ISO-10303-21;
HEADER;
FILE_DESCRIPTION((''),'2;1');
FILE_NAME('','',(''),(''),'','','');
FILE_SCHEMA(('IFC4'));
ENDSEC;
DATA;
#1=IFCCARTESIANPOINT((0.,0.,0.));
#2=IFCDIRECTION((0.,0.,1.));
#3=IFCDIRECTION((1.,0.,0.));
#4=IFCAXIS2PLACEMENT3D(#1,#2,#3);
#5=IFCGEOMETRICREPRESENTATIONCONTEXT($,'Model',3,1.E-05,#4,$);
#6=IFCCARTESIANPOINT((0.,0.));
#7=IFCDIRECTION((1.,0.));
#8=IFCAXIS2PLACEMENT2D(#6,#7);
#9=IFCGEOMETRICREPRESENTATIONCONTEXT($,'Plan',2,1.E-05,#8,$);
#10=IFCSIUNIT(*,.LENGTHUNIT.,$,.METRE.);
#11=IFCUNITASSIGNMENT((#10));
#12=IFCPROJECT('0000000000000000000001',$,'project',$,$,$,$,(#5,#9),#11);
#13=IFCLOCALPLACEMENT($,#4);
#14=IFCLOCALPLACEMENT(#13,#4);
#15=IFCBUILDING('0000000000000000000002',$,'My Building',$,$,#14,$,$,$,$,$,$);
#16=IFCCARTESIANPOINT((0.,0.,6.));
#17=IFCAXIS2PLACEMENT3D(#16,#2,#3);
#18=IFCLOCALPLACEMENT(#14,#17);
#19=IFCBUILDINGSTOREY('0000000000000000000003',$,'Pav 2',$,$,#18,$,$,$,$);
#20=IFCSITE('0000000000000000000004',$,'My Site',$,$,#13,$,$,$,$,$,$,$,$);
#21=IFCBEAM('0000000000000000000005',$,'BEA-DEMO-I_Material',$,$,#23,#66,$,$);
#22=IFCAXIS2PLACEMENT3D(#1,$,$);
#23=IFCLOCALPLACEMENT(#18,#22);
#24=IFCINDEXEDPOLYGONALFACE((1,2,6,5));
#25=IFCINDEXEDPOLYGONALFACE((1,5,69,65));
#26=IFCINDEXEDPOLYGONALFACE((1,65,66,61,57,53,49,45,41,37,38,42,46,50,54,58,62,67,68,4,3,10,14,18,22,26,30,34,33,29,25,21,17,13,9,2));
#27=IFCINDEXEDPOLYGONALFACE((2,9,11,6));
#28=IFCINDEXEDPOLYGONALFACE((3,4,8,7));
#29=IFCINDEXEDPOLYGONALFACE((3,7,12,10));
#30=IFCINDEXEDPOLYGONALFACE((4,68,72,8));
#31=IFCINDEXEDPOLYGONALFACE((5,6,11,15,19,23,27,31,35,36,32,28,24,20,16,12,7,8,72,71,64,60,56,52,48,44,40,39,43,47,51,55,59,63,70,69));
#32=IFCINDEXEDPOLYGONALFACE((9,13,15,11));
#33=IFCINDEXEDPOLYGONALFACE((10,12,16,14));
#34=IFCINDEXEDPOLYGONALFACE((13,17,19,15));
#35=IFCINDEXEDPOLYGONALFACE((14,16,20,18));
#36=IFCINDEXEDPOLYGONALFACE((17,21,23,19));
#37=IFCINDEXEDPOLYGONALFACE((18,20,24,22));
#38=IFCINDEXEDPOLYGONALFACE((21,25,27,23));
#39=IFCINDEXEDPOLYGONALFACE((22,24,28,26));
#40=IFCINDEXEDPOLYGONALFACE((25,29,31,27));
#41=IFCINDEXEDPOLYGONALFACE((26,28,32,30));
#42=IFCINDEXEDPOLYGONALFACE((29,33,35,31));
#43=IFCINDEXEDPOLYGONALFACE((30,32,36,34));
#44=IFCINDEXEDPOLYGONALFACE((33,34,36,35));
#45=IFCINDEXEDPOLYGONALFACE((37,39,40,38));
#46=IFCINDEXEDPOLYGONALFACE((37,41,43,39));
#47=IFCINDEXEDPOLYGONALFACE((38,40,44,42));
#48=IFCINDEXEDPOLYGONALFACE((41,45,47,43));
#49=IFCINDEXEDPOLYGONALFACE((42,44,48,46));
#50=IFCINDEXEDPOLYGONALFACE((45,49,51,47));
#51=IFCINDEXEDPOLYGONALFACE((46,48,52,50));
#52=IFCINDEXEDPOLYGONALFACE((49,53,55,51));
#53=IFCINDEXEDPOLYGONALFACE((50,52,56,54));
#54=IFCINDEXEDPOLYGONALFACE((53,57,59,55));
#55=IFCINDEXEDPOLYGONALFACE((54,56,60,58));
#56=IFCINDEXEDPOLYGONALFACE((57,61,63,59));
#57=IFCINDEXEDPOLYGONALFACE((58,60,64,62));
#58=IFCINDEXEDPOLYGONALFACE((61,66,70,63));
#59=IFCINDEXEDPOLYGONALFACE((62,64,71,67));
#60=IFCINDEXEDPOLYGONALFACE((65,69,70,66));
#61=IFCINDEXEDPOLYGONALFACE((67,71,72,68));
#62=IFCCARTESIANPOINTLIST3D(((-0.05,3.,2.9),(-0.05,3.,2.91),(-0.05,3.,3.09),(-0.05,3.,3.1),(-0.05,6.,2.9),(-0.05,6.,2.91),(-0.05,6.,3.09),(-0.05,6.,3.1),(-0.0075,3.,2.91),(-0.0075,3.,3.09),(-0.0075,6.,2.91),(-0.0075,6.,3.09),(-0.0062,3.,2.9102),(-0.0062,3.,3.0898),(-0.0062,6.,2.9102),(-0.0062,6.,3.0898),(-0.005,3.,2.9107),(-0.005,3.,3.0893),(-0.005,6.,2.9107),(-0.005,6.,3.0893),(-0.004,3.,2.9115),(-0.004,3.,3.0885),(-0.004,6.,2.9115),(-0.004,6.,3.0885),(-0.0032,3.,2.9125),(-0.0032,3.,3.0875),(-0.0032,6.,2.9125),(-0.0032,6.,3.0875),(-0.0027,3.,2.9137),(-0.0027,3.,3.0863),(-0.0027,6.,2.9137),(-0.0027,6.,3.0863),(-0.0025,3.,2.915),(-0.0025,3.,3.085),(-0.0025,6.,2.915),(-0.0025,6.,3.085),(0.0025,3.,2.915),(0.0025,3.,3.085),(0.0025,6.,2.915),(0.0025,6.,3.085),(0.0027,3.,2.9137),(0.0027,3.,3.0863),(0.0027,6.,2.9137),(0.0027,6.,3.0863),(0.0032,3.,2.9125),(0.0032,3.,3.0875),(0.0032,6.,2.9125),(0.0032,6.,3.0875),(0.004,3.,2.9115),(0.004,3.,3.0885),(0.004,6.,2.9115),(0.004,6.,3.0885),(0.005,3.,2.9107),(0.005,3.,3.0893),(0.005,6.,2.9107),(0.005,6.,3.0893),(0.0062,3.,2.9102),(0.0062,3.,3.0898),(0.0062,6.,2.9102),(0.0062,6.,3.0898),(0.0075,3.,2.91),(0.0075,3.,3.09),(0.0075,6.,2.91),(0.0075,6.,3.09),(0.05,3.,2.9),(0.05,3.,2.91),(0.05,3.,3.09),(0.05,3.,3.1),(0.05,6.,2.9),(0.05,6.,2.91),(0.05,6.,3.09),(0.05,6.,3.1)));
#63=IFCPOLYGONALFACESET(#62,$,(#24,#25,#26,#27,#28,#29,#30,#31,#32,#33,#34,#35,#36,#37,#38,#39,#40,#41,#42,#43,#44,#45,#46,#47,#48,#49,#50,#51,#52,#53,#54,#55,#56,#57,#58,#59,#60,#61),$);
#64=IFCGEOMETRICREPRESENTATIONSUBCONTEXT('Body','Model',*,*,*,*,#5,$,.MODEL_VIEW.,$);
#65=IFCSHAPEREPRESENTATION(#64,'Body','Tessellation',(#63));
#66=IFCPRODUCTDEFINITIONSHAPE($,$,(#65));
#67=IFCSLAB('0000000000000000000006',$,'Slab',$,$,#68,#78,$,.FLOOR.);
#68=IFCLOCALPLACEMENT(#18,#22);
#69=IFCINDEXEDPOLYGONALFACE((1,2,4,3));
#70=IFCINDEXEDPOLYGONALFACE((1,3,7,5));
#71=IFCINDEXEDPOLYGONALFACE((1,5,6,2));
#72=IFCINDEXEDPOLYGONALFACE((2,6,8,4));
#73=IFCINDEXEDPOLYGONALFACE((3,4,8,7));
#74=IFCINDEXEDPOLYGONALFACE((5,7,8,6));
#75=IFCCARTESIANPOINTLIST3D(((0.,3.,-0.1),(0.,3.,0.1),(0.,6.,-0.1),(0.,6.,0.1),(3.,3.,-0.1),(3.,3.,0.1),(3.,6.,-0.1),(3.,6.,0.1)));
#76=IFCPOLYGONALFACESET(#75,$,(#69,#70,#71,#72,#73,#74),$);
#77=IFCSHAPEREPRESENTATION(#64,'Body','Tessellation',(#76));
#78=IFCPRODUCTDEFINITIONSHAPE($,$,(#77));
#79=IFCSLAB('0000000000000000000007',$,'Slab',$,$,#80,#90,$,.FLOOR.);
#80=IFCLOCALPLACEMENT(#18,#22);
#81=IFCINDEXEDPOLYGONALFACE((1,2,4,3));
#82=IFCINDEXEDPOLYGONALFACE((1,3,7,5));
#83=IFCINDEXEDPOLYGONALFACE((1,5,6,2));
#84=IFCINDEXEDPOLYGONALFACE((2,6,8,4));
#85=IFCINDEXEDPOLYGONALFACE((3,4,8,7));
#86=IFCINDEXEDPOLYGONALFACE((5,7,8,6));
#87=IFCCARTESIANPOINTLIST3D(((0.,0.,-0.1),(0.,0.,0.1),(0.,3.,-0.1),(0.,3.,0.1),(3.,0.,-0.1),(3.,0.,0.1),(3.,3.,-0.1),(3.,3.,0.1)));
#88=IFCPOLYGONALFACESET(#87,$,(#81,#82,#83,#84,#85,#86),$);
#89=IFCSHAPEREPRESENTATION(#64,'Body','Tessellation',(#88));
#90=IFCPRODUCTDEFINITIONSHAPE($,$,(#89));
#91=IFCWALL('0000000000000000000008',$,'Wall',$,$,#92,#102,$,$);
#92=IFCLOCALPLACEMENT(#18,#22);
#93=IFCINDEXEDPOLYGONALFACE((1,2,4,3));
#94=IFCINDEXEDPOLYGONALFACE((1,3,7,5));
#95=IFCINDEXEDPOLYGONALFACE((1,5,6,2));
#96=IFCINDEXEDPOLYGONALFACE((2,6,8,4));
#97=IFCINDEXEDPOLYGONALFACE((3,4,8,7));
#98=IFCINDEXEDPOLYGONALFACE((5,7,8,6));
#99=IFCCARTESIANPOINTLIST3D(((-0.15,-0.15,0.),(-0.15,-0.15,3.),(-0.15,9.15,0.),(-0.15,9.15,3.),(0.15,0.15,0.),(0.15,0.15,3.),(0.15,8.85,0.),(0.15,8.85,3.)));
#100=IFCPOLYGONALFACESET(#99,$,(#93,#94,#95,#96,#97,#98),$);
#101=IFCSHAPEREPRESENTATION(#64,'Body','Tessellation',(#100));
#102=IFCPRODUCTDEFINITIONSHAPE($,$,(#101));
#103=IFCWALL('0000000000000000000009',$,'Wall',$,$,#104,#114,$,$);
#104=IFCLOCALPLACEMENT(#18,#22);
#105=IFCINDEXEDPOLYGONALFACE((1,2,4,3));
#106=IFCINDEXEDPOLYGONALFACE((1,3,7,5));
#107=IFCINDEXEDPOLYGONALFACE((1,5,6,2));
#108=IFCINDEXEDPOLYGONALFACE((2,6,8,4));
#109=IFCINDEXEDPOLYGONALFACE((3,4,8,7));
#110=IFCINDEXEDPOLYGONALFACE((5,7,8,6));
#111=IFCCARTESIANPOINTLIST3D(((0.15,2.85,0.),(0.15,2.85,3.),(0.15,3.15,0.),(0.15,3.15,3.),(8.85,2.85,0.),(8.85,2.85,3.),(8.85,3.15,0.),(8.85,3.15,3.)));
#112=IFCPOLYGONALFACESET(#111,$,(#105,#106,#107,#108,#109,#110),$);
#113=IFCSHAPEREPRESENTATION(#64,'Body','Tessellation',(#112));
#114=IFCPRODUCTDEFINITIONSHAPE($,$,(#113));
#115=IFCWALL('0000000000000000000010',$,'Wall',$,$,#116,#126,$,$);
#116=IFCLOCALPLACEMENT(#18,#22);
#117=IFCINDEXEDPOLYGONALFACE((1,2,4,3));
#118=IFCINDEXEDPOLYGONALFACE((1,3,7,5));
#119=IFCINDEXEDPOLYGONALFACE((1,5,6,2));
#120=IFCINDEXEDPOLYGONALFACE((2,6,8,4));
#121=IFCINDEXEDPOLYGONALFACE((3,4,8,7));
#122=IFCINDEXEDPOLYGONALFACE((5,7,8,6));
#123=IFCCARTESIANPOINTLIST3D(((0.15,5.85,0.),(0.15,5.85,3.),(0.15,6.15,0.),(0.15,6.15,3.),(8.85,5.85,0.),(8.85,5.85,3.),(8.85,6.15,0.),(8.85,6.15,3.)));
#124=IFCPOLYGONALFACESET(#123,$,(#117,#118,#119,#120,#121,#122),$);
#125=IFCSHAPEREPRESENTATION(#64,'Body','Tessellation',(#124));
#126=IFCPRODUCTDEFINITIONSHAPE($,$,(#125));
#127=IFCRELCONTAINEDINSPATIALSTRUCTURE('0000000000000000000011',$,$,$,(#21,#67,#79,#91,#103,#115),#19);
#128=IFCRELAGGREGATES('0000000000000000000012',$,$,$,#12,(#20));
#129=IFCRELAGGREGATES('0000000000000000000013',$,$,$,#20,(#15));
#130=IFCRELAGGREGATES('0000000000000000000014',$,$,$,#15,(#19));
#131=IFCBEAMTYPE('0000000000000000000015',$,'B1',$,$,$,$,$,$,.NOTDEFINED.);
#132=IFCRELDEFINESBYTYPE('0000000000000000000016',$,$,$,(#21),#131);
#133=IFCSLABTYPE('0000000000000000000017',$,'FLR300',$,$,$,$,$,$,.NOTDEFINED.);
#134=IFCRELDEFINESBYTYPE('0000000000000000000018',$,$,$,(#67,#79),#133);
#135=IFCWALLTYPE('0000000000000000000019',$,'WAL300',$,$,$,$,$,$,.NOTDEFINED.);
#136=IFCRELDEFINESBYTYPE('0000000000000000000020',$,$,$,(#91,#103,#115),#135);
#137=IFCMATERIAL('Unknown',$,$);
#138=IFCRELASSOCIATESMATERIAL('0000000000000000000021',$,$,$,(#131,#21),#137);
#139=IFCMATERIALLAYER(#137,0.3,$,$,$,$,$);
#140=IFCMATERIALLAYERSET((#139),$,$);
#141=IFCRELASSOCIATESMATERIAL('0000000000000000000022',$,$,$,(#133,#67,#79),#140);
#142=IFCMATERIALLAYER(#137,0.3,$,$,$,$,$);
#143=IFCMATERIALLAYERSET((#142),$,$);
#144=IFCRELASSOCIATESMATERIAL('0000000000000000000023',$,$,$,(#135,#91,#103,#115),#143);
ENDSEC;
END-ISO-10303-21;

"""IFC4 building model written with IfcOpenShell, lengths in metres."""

from ifc_helpers import new_model, si_unit, frame, origin, origin_with_axes, origin_2d_with_axis, place, context, subcontext, project, spatial, polyline, line, indexed_curve, i_section, outline, extrude, material, layer, layer_set, layer_usage, material_profile, profile_set, profile_usage, type_object, element, save


model = new_model("IFC4")

# Units and contexts
model_context = context("Model", 3, precision=1e-05, world=origin_with_axes())
plan_context = context("Plan", 2, precision=1e-05, world=origin_2d_with_axis())
body_context = subcontext(model_context, "Body", "Model", "MODEL_VIEW")
ifc_project = project(units=[si_unit("LENGTHUNIT", "METRE")], contexts=[model_context, plan_context])

# Site, building, storey
site_placement = place(None, origin_with_axes())
site = spatial("IfcSite", under=ifc_project, at=site_placement, Name="My Site")
building_placement = place(site_placement, origin_with_axes())
building = spatial("IfcBuilding", under=site, at=building_placement, Name="My Building")
storey_placement = place(building_placement, frame((0.0, 0.0, 6.0), z_axis=(0.0, 0.0, 1.0), x_axis=(1.0, 0.0, 0.0)))
storey = spatial("IfcBuildingStorey", under=building, at=storey_placement, Name="Pav 2")

# Beam
ifc_material = material(Name="Unknown")
ifc_material_profile = material_profile(ifc_material, i_section(OverallWidth=0.1, OverallDepth=0.2, WebThickness=0.005, FlangeThickness=0.01, FilletRadius=0.005))
ifc_profile_set = profile_set([ifc_material_profile])
beam_type = type_object("IfcBeamType", Name="B1", PredefinedType="NOTDEFINED", material=ifc_profile_set)
ifc_profile_usage_1 = profile_usage(ifc_profile_set, cardinal=5)
beam_1_placement = place(storey_placement, frame((0.0, 3.0, 3.0), z_axis=(0.0, 1.0, 0.0), x_axis=(-1.0, 0.0, 0.0)))
element("IfcBeam", 1, at=beam_1_placement, inside=storey, type_object=beam_type, material=ifc_profile_usage_1, Name="BEA-DEMO-I_Material", context=body_context, shape_type="SweptSolid", body=[
    extrude(i_section(OverallWidth=0.1, OverallDepth=0.2, WebThickness=0.005, FlangeThickness=0.01, FilletRadius=0.005), origin(), (0.0, 0.0, 1.0), 3.0),
])

# Slabs
ifc_layer_1 = layer(ifc_material, 0.3)
ifc_layer_set_1 = layer_set([ifc_layer_1])
ifc_layer_usage_1 = layer_usage(ifc_layer_set_1, "AXIS3", "POSITIVE", 0.0)
slab_type = type_object("IfcSlabType", Name="FLR300", PredefinedType="NOTDEFINED", material=ifc_layer_set_1)
slab_1_placement = place(storey_placement, frame((1.5, 4.5, -0.1), z_axis=(0.0, 0.0, 1.0), x_axis=(1.0, 0.0, 0.0)))
element("IfcSlab", 2, at=slab_1_placement, inside=storey, type_object=slab_type, material=ifc_layer_usage_1, Name="Slab", PredefinedType="FLOOR", context=body_context, shape_type="SweptSolid", body=[
    extrude(outline(polyline([(1.5, 1.5), (-1.5, 1.5), (-1.5, -1.5), (1.5, -1.5), (1.5, 1.5)])), origin(), (0.0, 0.0, 1.0), 0.2),
])
ifc_layer_usage_2 = layer_usage(ifc_layer_set_1, "AXIS3", "POSITIVE", 0.0)
slab_2_placement = place(storey_placement, frame((1.5, 1.5, -0.1), z_axis=(0.0, 0.0, 1.0), x_axis=(1.0, 0.0, 0.0)))
element("IfcSlab", 3, at=slab_2_placement, inside=storey, type_object=slab_type, material=ifc_layer_usage_2, Name="Slab", PredefinedType="FLOOR", context=body_context, shape_type="SweptSolid", body=[
    extrude(outline(polyline([(1.5, 1.5), (-1.5, 1.5), (-1.5, -1.5), (1.5, -1.5), (1.5, 1.5)])), origin(), (0.0, 0.0, 1.0), 0.2),
])

# Walls
ifc_layer_2 = layer(ifc_material, 0.3)
ifc_layer_set_2 = layer_set([ifc_layer_2])
ifc_layer_usage_3 = layer_usage(ifc_layer_set_2, "AXIS2", "POSITIVE", -0.15)
wall_type = type_object("IfcWallType", Name="WAL300", PredefinedType="NOTDEFINED", material=ifc_layer_set_2)
wall_1_placement = place(storey_placement, frame((0.0, 0.0, 0.0), z_axis=(0.0, 0.0, 1.0), x_axis=(0.0, 1.0, 0.0)))
element("IfcWall", 4, at=wall_1_placement, inside=storey, type_object=wall_type, material=ifc_layer_usage_3, Name="Wall", context=body_context, shape_type="SweptSolid", body=[
    extrude(outline(indexed_curve([(0.15, -0.15), (-0.15, 0.15), (9.15, 0.15), (8.85, -0.15)], segments=[line(1, 2, 3, 4, 1)])), origin_with_axes(), (0.0, 0.0, 1.0), 3.0),
])
ifc_layer_usage_4 = layer_usage(ifc_layer_set_2, "AXIS2", "POSITIVE", -0.15)
wall_2_placement = place(storey_placement, frame((0.0, 3.0, 0.0), z_axis=(0.0, 0.0, 1.0), x_axis=(1.0, 0.0, 0.0)))
element("IfcWall", 5, at=wall_2_placement, inside=storey, type_object=wall_type, material=ifc_layer_usage_4, Name="Wall", context=body_context, shape_type="SweptSolid", body=[
    extrude(outline(indexed_curve([(0.15, -0.15), (0.15, 0.15), (8.85, 0.15), (8.85, -0.15)], segments=[line(1, 2, 3, 4, 1)])), origin_with_axes(), (0.0, 0.0, 1.0), 3.0),
])
ifc_layer_usage_5 = layer_usage(ifc_layer_set_2, "AXIS2", "POSITIVE", -0.15)
wall_3_placement = place(storey_placement, frame((0.0, 6.0, 0.0), z_axis=(0.0, 0.0, 1.0), x_axis=(1.0, 0.0, 0.0)))
element("IfcWall", 6, at=wall_3_placement, inside=storey, type_object=wall_type, material=ifc_layer_usage_5, Name="Wall", context=body_context, shape_type="SweptSolid", body=[
    extrude(outline(indexed_curve([(0.15, -0.15), (0.15, 0.15), (8.85, 0.15), (8.85, -0.15)], segments=[line(1, 2, 3, 4, 1)])), origin_with_axes(), (0.0, 0.0, 1.0), 3.0),
])

save(model, "model.ifc")
